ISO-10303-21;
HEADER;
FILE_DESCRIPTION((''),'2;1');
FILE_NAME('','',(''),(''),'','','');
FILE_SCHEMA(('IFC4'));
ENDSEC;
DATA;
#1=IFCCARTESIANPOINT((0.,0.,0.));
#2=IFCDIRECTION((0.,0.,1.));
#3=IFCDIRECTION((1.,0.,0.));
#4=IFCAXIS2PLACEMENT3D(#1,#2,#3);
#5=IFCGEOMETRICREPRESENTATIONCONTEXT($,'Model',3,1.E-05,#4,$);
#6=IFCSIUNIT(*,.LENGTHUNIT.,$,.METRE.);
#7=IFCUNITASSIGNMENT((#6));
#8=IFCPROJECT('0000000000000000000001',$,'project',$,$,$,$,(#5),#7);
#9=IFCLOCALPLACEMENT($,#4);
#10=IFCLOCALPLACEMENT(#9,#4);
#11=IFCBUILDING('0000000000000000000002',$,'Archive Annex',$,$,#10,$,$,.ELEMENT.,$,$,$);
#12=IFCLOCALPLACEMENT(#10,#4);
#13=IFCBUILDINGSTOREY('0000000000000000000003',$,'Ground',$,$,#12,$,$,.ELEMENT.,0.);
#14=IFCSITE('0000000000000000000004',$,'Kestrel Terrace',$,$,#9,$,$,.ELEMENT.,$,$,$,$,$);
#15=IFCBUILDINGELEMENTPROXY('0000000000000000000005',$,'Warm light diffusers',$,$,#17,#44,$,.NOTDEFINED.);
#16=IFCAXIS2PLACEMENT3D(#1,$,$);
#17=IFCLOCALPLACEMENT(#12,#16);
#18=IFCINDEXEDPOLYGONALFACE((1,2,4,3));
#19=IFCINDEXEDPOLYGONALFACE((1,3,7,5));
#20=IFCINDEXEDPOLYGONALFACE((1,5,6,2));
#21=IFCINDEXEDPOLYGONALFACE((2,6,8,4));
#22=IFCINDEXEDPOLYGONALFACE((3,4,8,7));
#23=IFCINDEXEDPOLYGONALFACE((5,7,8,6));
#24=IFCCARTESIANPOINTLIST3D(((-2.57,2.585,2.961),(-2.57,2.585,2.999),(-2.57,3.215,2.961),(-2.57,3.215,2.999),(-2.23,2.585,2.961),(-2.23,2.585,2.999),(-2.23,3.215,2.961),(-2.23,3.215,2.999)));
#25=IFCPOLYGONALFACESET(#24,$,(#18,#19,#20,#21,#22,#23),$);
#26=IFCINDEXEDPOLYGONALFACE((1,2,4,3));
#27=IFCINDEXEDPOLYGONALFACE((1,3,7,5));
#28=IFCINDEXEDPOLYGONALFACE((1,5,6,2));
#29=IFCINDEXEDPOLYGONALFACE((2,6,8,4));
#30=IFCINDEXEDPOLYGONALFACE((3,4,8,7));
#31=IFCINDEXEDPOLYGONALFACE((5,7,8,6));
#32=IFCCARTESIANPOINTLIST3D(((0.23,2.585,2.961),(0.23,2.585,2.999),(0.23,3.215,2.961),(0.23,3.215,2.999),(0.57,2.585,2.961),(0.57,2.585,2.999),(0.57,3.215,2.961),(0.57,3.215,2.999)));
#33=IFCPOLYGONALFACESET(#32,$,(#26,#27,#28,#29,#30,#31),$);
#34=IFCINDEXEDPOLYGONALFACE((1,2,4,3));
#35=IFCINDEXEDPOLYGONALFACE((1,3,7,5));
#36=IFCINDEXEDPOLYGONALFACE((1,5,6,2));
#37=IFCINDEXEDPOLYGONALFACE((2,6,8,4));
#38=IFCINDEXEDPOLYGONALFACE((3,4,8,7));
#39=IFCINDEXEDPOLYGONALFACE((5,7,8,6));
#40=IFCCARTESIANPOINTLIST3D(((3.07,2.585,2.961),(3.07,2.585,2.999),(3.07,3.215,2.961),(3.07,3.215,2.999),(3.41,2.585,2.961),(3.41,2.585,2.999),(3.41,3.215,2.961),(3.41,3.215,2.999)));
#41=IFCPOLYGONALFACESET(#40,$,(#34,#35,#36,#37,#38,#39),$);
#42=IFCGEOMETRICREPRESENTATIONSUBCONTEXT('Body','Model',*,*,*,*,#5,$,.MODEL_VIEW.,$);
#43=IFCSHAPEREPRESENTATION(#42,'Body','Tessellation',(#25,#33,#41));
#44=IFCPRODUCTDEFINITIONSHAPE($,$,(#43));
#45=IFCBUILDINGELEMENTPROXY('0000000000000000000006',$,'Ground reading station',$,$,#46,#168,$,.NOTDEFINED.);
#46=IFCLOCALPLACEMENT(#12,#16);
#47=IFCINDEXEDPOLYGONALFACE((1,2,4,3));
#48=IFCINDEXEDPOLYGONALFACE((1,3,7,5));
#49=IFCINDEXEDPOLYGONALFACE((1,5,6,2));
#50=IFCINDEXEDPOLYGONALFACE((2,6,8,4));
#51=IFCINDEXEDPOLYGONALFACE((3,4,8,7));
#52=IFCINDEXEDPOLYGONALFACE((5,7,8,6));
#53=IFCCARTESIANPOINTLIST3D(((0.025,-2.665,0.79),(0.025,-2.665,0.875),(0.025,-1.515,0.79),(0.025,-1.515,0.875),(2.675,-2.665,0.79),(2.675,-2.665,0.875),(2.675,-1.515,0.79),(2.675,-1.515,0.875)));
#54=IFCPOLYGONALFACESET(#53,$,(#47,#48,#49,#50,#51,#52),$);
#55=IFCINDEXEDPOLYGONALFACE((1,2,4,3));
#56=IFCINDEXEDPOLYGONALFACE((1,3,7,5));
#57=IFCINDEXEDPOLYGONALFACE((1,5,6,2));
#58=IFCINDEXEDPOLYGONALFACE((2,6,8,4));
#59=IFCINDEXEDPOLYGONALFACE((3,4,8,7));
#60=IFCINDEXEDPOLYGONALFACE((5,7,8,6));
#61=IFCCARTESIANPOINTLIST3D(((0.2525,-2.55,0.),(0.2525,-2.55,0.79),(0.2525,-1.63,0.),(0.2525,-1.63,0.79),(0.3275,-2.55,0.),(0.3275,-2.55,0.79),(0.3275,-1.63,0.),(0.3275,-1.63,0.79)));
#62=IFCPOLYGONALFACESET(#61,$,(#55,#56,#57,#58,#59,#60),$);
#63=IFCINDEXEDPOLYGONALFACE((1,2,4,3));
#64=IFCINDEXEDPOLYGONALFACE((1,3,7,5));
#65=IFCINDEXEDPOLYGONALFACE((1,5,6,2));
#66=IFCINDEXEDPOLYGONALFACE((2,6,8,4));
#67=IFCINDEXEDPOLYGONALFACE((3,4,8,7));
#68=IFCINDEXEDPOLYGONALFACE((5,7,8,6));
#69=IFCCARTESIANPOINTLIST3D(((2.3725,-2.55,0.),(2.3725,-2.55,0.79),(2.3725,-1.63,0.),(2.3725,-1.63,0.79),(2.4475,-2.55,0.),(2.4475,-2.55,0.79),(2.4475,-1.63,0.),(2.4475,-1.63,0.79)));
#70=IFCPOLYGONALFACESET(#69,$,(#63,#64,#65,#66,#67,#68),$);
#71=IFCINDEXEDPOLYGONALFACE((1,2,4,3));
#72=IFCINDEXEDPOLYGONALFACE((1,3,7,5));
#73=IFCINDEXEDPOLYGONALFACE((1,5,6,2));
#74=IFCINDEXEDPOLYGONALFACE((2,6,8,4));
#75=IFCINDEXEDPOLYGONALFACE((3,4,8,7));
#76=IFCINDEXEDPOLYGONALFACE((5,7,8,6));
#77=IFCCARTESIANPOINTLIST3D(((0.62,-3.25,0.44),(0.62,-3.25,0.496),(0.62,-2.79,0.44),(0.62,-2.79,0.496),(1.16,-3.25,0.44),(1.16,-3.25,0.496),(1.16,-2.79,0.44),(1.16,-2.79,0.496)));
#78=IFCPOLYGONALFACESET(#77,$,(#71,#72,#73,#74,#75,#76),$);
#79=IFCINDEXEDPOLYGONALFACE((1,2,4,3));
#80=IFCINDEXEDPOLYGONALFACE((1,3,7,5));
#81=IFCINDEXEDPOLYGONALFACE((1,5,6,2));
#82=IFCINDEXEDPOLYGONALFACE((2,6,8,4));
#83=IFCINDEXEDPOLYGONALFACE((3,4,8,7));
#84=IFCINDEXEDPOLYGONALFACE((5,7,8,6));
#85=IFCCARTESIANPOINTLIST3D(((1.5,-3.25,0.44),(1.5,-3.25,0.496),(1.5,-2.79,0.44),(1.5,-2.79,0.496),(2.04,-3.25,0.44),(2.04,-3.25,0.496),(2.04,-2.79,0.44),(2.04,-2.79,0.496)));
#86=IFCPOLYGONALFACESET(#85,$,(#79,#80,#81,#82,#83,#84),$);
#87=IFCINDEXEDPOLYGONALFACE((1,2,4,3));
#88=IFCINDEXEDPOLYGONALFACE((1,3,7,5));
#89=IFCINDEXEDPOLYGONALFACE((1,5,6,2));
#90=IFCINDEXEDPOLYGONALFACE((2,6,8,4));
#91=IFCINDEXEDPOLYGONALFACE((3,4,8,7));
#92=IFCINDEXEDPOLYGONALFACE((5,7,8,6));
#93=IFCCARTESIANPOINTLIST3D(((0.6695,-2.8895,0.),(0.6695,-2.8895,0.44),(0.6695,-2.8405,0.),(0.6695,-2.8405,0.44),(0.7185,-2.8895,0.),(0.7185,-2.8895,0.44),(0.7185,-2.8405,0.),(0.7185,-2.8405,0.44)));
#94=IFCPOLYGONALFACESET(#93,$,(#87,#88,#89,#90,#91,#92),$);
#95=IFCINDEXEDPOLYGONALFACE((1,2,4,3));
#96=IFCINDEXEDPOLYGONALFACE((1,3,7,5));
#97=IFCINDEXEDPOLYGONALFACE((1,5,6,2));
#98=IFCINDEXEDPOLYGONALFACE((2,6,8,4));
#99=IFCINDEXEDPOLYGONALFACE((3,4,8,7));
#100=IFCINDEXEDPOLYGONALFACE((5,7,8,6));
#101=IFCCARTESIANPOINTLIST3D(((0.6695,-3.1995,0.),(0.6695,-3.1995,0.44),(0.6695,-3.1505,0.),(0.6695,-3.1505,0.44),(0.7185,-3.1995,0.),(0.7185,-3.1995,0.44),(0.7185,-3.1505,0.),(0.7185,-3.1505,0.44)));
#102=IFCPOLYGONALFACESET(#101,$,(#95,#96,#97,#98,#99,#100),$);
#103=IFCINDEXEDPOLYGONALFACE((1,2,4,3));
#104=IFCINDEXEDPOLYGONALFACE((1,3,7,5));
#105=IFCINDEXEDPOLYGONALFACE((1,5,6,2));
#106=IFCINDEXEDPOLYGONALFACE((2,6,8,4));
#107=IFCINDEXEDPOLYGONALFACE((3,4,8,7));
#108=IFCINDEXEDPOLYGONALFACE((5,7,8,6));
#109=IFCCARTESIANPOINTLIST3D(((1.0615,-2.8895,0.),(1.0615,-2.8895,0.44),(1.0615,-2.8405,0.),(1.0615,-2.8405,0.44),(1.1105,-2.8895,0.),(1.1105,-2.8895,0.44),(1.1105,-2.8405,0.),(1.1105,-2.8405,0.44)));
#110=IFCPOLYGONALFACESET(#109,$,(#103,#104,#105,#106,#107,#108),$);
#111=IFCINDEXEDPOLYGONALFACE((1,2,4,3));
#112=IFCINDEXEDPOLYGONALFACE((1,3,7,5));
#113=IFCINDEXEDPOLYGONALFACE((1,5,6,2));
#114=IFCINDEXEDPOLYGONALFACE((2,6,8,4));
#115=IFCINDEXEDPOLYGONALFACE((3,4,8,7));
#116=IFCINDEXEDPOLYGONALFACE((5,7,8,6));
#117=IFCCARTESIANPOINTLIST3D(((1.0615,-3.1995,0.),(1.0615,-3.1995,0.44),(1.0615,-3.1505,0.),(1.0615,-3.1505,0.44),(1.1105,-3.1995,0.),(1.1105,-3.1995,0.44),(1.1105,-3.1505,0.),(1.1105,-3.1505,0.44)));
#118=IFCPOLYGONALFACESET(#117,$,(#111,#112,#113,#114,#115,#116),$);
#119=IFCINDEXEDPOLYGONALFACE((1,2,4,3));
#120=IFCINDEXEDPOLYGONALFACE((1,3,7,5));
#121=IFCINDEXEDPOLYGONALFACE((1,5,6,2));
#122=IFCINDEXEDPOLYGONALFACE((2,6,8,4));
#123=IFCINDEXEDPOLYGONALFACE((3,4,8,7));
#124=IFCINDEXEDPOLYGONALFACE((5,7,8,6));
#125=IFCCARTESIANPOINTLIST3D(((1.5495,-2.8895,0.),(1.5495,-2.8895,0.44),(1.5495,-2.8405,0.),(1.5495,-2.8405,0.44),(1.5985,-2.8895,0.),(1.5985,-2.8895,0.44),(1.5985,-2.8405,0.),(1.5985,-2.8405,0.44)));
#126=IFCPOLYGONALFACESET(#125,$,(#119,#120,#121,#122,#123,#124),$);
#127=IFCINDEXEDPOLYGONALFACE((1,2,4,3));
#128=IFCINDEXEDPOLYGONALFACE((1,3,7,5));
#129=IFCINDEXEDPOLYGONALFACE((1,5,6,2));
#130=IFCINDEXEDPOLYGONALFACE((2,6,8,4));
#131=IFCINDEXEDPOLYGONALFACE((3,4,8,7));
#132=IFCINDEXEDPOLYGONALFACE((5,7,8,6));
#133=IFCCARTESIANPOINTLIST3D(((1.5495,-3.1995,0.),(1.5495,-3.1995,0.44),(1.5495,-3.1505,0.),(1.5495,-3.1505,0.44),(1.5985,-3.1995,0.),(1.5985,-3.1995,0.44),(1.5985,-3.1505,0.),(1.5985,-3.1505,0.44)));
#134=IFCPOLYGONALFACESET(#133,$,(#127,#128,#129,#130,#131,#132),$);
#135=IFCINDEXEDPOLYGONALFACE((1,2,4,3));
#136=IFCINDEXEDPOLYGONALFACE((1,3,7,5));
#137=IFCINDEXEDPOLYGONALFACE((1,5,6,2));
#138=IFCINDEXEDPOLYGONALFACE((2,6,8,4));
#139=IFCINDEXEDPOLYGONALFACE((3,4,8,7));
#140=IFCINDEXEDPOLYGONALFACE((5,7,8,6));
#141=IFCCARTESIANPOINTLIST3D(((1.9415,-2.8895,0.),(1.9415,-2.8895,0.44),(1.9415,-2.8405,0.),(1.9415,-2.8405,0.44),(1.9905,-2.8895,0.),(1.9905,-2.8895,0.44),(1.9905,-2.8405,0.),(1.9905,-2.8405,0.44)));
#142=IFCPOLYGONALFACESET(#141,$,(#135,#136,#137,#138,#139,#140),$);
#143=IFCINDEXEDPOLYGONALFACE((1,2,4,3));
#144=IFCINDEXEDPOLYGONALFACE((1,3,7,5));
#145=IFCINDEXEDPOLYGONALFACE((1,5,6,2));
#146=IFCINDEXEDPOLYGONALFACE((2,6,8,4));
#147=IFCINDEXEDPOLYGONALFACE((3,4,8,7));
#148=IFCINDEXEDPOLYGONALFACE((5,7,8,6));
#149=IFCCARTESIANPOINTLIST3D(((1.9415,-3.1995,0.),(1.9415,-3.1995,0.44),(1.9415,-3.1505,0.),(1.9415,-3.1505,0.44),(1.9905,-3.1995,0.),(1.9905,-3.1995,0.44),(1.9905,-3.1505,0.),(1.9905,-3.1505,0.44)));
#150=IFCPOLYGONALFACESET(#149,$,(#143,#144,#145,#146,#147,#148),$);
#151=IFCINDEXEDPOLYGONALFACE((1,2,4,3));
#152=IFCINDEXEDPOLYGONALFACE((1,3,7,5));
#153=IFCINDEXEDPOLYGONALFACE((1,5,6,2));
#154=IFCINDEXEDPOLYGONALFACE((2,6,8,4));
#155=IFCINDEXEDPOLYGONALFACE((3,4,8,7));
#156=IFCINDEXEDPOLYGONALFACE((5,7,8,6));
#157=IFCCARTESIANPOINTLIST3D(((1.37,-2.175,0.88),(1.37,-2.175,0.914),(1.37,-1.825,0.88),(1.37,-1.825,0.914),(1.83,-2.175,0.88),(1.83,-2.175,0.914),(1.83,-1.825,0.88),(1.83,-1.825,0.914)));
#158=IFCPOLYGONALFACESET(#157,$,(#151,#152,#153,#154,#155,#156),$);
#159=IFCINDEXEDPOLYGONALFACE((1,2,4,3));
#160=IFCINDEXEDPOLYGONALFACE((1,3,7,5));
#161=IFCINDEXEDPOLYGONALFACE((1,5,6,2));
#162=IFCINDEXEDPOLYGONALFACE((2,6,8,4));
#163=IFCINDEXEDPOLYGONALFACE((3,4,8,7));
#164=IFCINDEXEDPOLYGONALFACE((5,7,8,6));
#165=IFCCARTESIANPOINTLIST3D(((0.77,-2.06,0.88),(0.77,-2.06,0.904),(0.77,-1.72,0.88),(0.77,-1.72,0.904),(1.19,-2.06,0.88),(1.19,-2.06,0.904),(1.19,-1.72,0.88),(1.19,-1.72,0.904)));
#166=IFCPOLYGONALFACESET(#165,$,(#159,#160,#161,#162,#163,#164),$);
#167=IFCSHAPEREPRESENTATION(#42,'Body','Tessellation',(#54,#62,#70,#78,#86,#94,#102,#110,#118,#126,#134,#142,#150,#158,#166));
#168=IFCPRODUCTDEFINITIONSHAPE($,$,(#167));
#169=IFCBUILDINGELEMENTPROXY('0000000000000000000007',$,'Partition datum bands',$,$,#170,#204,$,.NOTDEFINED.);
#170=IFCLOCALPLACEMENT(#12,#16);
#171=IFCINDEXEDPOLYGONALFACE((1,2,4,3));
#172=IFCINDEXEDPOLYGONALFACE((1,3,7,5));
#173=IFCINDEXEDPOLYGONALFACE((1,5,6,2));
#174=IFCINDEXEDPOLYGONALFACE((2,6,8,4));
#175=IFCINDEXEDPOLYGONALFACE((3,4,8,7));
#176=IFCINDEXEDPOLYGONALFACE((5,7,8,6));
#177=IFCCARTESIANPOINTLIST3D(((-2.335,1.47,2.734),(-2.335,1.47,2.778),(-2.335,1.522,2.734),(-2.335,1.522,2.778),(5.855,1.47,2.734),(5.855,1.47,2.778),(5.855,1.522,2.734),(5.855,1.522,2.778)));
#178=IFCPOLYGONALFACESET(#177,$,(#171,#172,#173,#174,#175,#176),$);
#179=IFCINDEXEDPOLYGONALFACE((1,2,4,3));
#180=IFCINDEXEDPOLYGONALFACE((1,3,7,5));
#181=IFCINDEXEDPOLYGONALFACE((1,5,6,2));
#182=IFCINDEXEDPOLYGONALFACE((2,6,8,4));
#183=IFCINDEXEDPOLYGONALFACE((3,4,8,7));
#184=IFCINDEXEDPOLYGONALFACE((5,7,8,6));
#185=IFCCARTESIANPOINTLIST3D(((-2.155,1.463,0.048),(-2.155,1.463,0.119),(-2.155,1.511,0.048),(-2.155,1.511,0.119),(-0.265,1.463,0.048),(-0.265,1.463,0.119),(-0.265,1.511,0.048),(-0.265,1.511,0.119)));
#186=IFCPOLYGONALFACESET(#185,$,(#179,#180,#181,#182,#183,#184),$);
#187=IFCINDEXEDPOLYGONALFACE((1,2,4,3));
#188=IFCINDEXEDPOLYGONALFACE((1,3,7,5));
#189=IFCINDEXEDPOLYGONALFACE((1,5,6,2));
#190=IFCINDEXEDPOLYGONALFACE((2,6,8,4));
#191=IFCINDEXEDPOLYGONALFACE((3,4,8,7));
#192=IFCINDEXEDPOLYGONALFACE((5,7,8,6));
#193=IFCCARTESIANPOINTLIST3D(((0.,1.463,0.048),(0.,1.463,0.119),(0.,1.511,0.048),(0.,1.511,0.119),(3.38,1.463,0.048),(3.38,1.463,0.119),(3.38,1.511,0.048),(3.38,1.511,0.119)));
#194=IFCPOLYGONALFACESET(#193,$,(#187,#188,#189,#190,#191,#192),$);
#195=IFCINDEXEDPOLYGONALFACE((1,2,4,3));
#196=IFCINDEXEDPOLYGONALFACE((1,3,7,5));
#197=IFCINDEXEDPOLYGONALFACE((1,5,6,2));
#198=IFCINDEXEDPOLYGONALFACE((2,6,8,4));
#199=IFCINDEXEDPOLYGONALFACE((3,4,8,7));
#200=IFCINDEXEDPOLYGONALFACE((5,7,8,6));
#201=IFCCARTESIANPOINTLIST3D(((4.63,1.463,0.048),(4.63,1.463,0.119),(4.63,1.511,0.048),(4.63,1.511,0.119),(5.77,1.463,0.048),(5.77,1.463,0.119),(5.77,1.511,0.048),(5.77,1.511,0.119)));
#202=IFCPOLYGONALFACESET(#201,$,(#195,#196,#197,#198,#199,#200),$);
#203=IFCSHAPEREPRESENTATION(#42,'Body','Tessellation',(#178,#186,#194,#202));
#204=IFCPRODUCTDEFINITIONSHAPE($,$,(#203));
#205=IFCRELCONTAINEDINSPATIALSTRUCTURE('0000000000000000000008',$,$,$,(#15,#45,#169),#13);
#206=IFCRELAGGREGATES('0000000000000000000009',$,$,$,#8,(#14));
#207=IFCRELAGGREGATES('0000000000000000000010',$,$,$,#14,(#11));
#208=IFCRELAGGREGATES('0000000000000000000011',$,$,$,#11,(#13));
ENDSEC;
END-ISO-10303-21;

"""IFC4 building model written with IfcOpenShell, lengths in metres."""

from ifc_helpers import new_model, si_unit, frame, origin_with_axes, origin_2d, place, context, subcontext, project, spatial, rectangle, extrude, element, save


model = new_model("IFC4")

# Units and contexts
model_context = context("Model", 3, precision=1e-05, world=origin_with_axes())
body_context = subcontext(model_context, "Body", "Model", "MODEL_VIEW")
ifc_project = project(units=[si_unit("LENGTHUNIT", "METRE")], contexts=[model_context])

# Site, building, storey
site_placement = place(None, origin_with_axes())
site = spatial("IfcSite", under=ifc_project, at=site_placement, Name="Kestrel Terrace", CompositionType="ELEMENT")
building_placement = place(site_placement, origin_with_axes())
building = spatial("IfcBuilding", under=site, at=building_placement, Name="Archive Annex", CompositionType="ELEMENT")
storey_placement = place(building_placement, origin_with_axes())
storey = spatial("IfcBuildingStorey", under=building, at=storey_placement, Name="Ground", CompositionType="ELEMENT", Elevation=0.0)

# Building element proxies
proxy_1_placement = place(storey_placement, origin_with_axes())
element("IfcBuildingElementProxy", 1, at=proxy_1_placement, inside=storey, Name="Warm light diffusers", PredefinedType="NOTDEFINED", context=body_context, shape_type="SweptSolid", body=[
    extrude(rectangle(XDim=0.34, YDim=0.63, at=origin_2d()), frame((-2.4, 2.9, 2.961), z_axis=(0.0, 0.0, 1.0), x_axis=(1.0, 0.0, 0.0)), (0.0, 0.0, 1.0), 0.038),
    extrude(rectangle(XDim=0.34, YDim=0.63, at=origin_2d()), frame((0.4, 2.9, 2.961), z_axis=(0.0, 0.0, 1.0), x_axis=(1.0, 0.0, 0.0)), (0.0, 0.0, 1.0), 0.038),
    extrude(rectangle(XDim=0.34, YDim=0.63, at=origin_2d()), frame((3.24, 2.9, 2.961), z_axis=(0.0, 0.0, 1.0), x_axis=(1.0, 0.0, 0.0)), (0.0, 0.0, 1.0), 0.038),
])
proxy_2_placement = place(storey_placement, origin_with_axes())
element("IfcBuildingElementProxy", 2, at=proxy_2_placement, inside=storey, Name="Ground reading station", PredefinedType="NOTDEFINED", context=body_context, shape_type="SweptSolid", body=[
    extrude(rectangle(XDim=2.65, YDim=1.15, at=origin_2d()), frame((1.35, -2.09, 0.79), z_axis=(0.0, 0.0, 1.0), x_axis=(1.0, 0.0, 0.0)), (0.0, 0.0, 1.0), 0.085),
    extrude(rectangle(XDim=0.075, YDim=0.92, at=origin_2d()), frame((0.29, -2.09, 0.0), z_axis=(0.0, 0.0, 1.0), x_axis=(1.0, 0.0, 0.0)), (0.0, 0.0, 1.0), 0.79),
    extrude(rectangle(XDim=0.075, YDim=0.92, at=origin_2d()), frame((2.41, -2.09, 0.0), z_axis=(0.0, 0.0, 1.0), x_axis=(1.0, 0.0, 0.0)), (0.0, 0.0, 1.0), 0.79),
    extrude(rectangle(XDim=0.54, YDim=0.46, at=origin_2d()), frame((0.89, -3.02, 0.44), z_axis=(0.0, 0.0, 1.0), x_axis=(1.0, 0.0, 0.0)), (0.0, 0.0, 1.0), 0.056),
    extrude(rectangle(XDim=0.54, YDim=0.46, at=origin_2d()), frame((1.77, -3.02, 0.44), z_axis=(0.0, 0.0, 1.0), x_axis=(1.0, 0.0, 0.0)), (0.0, 0.0, 1.0), 0.056),
    extrude(rectangle(XDim=0.049, YDim=0.049, at=origin_2d()), frame((0.694, -2.865, 0.0), z_axis=(0.0, 0.0, 1.0), x_axis=(1.0, 0.0, 0.0)), (0.0, 0.0, 1.0), 0.44),
    extrude(rectangle(XDim=0.049, YDim=0.049, at=origin_2d()), frame((0.694, -3.175, 0.0), z_axis=(0.0, 0.0, 1.0), x_axis=(1.0, 0.0, 0.0)), (0.0, 0.0, 1.0), 0.44),
    extrude(rectangle(XDim=0.049, YDim=0.049, at=origin_2d()), frame((1.086, -2.865, 0.0), z_axis=(0.0, 0.0, 1.0), x_axis=(1.0, 0.0, 0.0)), (0.0, 0.0, 1.0), 0.44),
    extrude(rectangle(XDim=0.049, YDim=0.049, at=origin_2d()), frame((1.086, -3.175, 0.0), z_axis=(0.0, 0.0, 1.0), x_axis=(1.0, 0.0, 0.0)), (0.0, 0.0, 1.0), 0.44),
    extrude(rectangle(XDim=0.049, YDim=0.049, at=origin_2d()), frame((1.574, -2.865, 0.0), z_axis=(0.0, 0.0, 1.0), x_axis=(1.0, 0.0, 0.0)), (0.0, 0.0, 1.0), 0.44),
    extrude(rectangle(XDim=0.049, YDim=0.049, at=origin_2d()), frame((1.574, -3.175, 0.0), z_axis=(0.0, 0.0, 1.0), x_axis=(1.0, 0.0, 0.0)), (0.0, 0.0, 1.0), 0.44),
    extrude(rectangle(XDim=0.049, YDim=0.049, at=origin_2d()), frame((1.966, -2.865, 0.0), z_axis=(0.0, 0.0, 1.0), x_axis=(1.0, 0.0, 0.0)), (0.0, 0.0, 1.0), 0.44),
    extrude(rectangle(XDim=0.049, YDim=0.049, at=origin_2d()), frame((1.966, -3.175, 0.0), z_axis=(0.0, 0.0, 1.0), x_axis=(1.0, 0.0, 0.0)), (0.0, 0.0, 1.0), 0.44),
    extrude(rectangle(XDim=0.46, YDim=0.35, at=origin_2d()), frame((1.6, -2.0, 0.88), z_axis=(0.0, 0.0, 1.0), x_axis=(1.0, 0.0, 0.0)), (0.0, 0.0, 1.0), 0.034),
    extrude(rectangle(XDim=0.42, YDim=0.34, at=origin_2d()), frame((0.98, -1.89, 0.88), z_axis=(0.0, 0.0, 1.0), x_axis=(1.0, 0.0, 0.0)), (0.0, 0.0, 1.0), 0.024),
])
proxy_3_placement = place(storey_placement, origin_with_axes())
element("IfcBuildingElementProxy", 3, at=proxy_3_placement, inside=storey, Name="Partition datum bands", PredefinedType="NOTDEFINED", context=body_context, shape_type="SweptSolid", body=[
    extrude(rectangle(XDim=8.19, YDim=0.052, at=origin_2d()), frame((1.76, 1.496, 2.734), z_axis=(0.0, 0.0, 1.0), x_axis=(1.0, 0.0, 0.0)), (0.0, 0.0, 1.0), 0.044),
    extrude(rectangle(XDim=1.89, YDim=0.048, at=origin_2d()), frame((-1.21, 1.487, 0.048), z_axis=(0.0, 0.0, 1.0), x_axis=(1.0, 0.0, 0.0)), (0.0, 0.0, 1.0), 0.071),
    extrude(rectangle(XDim=3.38, YDim=0.048, at=origin_2d()), frame((1.69, 1.487, 0.048), z_axis=(0.0, 0.0, 1.0), x_axis=(1.0, 0.0, 0.0)), (0.0, 0.0, 1.0), 0.071),
    extrude(rectangle(XDim=1.14, YDim=0.048, at=origin_2d()), frame((5.2, 1.487, 0.048), z_axis=(0.0, 0.0, 1.0), x_axis=(1.0, 0.0, 0.0)), (0.0, 0.0, 1.0), 0.071),
])

save(model, "model.ifc")
